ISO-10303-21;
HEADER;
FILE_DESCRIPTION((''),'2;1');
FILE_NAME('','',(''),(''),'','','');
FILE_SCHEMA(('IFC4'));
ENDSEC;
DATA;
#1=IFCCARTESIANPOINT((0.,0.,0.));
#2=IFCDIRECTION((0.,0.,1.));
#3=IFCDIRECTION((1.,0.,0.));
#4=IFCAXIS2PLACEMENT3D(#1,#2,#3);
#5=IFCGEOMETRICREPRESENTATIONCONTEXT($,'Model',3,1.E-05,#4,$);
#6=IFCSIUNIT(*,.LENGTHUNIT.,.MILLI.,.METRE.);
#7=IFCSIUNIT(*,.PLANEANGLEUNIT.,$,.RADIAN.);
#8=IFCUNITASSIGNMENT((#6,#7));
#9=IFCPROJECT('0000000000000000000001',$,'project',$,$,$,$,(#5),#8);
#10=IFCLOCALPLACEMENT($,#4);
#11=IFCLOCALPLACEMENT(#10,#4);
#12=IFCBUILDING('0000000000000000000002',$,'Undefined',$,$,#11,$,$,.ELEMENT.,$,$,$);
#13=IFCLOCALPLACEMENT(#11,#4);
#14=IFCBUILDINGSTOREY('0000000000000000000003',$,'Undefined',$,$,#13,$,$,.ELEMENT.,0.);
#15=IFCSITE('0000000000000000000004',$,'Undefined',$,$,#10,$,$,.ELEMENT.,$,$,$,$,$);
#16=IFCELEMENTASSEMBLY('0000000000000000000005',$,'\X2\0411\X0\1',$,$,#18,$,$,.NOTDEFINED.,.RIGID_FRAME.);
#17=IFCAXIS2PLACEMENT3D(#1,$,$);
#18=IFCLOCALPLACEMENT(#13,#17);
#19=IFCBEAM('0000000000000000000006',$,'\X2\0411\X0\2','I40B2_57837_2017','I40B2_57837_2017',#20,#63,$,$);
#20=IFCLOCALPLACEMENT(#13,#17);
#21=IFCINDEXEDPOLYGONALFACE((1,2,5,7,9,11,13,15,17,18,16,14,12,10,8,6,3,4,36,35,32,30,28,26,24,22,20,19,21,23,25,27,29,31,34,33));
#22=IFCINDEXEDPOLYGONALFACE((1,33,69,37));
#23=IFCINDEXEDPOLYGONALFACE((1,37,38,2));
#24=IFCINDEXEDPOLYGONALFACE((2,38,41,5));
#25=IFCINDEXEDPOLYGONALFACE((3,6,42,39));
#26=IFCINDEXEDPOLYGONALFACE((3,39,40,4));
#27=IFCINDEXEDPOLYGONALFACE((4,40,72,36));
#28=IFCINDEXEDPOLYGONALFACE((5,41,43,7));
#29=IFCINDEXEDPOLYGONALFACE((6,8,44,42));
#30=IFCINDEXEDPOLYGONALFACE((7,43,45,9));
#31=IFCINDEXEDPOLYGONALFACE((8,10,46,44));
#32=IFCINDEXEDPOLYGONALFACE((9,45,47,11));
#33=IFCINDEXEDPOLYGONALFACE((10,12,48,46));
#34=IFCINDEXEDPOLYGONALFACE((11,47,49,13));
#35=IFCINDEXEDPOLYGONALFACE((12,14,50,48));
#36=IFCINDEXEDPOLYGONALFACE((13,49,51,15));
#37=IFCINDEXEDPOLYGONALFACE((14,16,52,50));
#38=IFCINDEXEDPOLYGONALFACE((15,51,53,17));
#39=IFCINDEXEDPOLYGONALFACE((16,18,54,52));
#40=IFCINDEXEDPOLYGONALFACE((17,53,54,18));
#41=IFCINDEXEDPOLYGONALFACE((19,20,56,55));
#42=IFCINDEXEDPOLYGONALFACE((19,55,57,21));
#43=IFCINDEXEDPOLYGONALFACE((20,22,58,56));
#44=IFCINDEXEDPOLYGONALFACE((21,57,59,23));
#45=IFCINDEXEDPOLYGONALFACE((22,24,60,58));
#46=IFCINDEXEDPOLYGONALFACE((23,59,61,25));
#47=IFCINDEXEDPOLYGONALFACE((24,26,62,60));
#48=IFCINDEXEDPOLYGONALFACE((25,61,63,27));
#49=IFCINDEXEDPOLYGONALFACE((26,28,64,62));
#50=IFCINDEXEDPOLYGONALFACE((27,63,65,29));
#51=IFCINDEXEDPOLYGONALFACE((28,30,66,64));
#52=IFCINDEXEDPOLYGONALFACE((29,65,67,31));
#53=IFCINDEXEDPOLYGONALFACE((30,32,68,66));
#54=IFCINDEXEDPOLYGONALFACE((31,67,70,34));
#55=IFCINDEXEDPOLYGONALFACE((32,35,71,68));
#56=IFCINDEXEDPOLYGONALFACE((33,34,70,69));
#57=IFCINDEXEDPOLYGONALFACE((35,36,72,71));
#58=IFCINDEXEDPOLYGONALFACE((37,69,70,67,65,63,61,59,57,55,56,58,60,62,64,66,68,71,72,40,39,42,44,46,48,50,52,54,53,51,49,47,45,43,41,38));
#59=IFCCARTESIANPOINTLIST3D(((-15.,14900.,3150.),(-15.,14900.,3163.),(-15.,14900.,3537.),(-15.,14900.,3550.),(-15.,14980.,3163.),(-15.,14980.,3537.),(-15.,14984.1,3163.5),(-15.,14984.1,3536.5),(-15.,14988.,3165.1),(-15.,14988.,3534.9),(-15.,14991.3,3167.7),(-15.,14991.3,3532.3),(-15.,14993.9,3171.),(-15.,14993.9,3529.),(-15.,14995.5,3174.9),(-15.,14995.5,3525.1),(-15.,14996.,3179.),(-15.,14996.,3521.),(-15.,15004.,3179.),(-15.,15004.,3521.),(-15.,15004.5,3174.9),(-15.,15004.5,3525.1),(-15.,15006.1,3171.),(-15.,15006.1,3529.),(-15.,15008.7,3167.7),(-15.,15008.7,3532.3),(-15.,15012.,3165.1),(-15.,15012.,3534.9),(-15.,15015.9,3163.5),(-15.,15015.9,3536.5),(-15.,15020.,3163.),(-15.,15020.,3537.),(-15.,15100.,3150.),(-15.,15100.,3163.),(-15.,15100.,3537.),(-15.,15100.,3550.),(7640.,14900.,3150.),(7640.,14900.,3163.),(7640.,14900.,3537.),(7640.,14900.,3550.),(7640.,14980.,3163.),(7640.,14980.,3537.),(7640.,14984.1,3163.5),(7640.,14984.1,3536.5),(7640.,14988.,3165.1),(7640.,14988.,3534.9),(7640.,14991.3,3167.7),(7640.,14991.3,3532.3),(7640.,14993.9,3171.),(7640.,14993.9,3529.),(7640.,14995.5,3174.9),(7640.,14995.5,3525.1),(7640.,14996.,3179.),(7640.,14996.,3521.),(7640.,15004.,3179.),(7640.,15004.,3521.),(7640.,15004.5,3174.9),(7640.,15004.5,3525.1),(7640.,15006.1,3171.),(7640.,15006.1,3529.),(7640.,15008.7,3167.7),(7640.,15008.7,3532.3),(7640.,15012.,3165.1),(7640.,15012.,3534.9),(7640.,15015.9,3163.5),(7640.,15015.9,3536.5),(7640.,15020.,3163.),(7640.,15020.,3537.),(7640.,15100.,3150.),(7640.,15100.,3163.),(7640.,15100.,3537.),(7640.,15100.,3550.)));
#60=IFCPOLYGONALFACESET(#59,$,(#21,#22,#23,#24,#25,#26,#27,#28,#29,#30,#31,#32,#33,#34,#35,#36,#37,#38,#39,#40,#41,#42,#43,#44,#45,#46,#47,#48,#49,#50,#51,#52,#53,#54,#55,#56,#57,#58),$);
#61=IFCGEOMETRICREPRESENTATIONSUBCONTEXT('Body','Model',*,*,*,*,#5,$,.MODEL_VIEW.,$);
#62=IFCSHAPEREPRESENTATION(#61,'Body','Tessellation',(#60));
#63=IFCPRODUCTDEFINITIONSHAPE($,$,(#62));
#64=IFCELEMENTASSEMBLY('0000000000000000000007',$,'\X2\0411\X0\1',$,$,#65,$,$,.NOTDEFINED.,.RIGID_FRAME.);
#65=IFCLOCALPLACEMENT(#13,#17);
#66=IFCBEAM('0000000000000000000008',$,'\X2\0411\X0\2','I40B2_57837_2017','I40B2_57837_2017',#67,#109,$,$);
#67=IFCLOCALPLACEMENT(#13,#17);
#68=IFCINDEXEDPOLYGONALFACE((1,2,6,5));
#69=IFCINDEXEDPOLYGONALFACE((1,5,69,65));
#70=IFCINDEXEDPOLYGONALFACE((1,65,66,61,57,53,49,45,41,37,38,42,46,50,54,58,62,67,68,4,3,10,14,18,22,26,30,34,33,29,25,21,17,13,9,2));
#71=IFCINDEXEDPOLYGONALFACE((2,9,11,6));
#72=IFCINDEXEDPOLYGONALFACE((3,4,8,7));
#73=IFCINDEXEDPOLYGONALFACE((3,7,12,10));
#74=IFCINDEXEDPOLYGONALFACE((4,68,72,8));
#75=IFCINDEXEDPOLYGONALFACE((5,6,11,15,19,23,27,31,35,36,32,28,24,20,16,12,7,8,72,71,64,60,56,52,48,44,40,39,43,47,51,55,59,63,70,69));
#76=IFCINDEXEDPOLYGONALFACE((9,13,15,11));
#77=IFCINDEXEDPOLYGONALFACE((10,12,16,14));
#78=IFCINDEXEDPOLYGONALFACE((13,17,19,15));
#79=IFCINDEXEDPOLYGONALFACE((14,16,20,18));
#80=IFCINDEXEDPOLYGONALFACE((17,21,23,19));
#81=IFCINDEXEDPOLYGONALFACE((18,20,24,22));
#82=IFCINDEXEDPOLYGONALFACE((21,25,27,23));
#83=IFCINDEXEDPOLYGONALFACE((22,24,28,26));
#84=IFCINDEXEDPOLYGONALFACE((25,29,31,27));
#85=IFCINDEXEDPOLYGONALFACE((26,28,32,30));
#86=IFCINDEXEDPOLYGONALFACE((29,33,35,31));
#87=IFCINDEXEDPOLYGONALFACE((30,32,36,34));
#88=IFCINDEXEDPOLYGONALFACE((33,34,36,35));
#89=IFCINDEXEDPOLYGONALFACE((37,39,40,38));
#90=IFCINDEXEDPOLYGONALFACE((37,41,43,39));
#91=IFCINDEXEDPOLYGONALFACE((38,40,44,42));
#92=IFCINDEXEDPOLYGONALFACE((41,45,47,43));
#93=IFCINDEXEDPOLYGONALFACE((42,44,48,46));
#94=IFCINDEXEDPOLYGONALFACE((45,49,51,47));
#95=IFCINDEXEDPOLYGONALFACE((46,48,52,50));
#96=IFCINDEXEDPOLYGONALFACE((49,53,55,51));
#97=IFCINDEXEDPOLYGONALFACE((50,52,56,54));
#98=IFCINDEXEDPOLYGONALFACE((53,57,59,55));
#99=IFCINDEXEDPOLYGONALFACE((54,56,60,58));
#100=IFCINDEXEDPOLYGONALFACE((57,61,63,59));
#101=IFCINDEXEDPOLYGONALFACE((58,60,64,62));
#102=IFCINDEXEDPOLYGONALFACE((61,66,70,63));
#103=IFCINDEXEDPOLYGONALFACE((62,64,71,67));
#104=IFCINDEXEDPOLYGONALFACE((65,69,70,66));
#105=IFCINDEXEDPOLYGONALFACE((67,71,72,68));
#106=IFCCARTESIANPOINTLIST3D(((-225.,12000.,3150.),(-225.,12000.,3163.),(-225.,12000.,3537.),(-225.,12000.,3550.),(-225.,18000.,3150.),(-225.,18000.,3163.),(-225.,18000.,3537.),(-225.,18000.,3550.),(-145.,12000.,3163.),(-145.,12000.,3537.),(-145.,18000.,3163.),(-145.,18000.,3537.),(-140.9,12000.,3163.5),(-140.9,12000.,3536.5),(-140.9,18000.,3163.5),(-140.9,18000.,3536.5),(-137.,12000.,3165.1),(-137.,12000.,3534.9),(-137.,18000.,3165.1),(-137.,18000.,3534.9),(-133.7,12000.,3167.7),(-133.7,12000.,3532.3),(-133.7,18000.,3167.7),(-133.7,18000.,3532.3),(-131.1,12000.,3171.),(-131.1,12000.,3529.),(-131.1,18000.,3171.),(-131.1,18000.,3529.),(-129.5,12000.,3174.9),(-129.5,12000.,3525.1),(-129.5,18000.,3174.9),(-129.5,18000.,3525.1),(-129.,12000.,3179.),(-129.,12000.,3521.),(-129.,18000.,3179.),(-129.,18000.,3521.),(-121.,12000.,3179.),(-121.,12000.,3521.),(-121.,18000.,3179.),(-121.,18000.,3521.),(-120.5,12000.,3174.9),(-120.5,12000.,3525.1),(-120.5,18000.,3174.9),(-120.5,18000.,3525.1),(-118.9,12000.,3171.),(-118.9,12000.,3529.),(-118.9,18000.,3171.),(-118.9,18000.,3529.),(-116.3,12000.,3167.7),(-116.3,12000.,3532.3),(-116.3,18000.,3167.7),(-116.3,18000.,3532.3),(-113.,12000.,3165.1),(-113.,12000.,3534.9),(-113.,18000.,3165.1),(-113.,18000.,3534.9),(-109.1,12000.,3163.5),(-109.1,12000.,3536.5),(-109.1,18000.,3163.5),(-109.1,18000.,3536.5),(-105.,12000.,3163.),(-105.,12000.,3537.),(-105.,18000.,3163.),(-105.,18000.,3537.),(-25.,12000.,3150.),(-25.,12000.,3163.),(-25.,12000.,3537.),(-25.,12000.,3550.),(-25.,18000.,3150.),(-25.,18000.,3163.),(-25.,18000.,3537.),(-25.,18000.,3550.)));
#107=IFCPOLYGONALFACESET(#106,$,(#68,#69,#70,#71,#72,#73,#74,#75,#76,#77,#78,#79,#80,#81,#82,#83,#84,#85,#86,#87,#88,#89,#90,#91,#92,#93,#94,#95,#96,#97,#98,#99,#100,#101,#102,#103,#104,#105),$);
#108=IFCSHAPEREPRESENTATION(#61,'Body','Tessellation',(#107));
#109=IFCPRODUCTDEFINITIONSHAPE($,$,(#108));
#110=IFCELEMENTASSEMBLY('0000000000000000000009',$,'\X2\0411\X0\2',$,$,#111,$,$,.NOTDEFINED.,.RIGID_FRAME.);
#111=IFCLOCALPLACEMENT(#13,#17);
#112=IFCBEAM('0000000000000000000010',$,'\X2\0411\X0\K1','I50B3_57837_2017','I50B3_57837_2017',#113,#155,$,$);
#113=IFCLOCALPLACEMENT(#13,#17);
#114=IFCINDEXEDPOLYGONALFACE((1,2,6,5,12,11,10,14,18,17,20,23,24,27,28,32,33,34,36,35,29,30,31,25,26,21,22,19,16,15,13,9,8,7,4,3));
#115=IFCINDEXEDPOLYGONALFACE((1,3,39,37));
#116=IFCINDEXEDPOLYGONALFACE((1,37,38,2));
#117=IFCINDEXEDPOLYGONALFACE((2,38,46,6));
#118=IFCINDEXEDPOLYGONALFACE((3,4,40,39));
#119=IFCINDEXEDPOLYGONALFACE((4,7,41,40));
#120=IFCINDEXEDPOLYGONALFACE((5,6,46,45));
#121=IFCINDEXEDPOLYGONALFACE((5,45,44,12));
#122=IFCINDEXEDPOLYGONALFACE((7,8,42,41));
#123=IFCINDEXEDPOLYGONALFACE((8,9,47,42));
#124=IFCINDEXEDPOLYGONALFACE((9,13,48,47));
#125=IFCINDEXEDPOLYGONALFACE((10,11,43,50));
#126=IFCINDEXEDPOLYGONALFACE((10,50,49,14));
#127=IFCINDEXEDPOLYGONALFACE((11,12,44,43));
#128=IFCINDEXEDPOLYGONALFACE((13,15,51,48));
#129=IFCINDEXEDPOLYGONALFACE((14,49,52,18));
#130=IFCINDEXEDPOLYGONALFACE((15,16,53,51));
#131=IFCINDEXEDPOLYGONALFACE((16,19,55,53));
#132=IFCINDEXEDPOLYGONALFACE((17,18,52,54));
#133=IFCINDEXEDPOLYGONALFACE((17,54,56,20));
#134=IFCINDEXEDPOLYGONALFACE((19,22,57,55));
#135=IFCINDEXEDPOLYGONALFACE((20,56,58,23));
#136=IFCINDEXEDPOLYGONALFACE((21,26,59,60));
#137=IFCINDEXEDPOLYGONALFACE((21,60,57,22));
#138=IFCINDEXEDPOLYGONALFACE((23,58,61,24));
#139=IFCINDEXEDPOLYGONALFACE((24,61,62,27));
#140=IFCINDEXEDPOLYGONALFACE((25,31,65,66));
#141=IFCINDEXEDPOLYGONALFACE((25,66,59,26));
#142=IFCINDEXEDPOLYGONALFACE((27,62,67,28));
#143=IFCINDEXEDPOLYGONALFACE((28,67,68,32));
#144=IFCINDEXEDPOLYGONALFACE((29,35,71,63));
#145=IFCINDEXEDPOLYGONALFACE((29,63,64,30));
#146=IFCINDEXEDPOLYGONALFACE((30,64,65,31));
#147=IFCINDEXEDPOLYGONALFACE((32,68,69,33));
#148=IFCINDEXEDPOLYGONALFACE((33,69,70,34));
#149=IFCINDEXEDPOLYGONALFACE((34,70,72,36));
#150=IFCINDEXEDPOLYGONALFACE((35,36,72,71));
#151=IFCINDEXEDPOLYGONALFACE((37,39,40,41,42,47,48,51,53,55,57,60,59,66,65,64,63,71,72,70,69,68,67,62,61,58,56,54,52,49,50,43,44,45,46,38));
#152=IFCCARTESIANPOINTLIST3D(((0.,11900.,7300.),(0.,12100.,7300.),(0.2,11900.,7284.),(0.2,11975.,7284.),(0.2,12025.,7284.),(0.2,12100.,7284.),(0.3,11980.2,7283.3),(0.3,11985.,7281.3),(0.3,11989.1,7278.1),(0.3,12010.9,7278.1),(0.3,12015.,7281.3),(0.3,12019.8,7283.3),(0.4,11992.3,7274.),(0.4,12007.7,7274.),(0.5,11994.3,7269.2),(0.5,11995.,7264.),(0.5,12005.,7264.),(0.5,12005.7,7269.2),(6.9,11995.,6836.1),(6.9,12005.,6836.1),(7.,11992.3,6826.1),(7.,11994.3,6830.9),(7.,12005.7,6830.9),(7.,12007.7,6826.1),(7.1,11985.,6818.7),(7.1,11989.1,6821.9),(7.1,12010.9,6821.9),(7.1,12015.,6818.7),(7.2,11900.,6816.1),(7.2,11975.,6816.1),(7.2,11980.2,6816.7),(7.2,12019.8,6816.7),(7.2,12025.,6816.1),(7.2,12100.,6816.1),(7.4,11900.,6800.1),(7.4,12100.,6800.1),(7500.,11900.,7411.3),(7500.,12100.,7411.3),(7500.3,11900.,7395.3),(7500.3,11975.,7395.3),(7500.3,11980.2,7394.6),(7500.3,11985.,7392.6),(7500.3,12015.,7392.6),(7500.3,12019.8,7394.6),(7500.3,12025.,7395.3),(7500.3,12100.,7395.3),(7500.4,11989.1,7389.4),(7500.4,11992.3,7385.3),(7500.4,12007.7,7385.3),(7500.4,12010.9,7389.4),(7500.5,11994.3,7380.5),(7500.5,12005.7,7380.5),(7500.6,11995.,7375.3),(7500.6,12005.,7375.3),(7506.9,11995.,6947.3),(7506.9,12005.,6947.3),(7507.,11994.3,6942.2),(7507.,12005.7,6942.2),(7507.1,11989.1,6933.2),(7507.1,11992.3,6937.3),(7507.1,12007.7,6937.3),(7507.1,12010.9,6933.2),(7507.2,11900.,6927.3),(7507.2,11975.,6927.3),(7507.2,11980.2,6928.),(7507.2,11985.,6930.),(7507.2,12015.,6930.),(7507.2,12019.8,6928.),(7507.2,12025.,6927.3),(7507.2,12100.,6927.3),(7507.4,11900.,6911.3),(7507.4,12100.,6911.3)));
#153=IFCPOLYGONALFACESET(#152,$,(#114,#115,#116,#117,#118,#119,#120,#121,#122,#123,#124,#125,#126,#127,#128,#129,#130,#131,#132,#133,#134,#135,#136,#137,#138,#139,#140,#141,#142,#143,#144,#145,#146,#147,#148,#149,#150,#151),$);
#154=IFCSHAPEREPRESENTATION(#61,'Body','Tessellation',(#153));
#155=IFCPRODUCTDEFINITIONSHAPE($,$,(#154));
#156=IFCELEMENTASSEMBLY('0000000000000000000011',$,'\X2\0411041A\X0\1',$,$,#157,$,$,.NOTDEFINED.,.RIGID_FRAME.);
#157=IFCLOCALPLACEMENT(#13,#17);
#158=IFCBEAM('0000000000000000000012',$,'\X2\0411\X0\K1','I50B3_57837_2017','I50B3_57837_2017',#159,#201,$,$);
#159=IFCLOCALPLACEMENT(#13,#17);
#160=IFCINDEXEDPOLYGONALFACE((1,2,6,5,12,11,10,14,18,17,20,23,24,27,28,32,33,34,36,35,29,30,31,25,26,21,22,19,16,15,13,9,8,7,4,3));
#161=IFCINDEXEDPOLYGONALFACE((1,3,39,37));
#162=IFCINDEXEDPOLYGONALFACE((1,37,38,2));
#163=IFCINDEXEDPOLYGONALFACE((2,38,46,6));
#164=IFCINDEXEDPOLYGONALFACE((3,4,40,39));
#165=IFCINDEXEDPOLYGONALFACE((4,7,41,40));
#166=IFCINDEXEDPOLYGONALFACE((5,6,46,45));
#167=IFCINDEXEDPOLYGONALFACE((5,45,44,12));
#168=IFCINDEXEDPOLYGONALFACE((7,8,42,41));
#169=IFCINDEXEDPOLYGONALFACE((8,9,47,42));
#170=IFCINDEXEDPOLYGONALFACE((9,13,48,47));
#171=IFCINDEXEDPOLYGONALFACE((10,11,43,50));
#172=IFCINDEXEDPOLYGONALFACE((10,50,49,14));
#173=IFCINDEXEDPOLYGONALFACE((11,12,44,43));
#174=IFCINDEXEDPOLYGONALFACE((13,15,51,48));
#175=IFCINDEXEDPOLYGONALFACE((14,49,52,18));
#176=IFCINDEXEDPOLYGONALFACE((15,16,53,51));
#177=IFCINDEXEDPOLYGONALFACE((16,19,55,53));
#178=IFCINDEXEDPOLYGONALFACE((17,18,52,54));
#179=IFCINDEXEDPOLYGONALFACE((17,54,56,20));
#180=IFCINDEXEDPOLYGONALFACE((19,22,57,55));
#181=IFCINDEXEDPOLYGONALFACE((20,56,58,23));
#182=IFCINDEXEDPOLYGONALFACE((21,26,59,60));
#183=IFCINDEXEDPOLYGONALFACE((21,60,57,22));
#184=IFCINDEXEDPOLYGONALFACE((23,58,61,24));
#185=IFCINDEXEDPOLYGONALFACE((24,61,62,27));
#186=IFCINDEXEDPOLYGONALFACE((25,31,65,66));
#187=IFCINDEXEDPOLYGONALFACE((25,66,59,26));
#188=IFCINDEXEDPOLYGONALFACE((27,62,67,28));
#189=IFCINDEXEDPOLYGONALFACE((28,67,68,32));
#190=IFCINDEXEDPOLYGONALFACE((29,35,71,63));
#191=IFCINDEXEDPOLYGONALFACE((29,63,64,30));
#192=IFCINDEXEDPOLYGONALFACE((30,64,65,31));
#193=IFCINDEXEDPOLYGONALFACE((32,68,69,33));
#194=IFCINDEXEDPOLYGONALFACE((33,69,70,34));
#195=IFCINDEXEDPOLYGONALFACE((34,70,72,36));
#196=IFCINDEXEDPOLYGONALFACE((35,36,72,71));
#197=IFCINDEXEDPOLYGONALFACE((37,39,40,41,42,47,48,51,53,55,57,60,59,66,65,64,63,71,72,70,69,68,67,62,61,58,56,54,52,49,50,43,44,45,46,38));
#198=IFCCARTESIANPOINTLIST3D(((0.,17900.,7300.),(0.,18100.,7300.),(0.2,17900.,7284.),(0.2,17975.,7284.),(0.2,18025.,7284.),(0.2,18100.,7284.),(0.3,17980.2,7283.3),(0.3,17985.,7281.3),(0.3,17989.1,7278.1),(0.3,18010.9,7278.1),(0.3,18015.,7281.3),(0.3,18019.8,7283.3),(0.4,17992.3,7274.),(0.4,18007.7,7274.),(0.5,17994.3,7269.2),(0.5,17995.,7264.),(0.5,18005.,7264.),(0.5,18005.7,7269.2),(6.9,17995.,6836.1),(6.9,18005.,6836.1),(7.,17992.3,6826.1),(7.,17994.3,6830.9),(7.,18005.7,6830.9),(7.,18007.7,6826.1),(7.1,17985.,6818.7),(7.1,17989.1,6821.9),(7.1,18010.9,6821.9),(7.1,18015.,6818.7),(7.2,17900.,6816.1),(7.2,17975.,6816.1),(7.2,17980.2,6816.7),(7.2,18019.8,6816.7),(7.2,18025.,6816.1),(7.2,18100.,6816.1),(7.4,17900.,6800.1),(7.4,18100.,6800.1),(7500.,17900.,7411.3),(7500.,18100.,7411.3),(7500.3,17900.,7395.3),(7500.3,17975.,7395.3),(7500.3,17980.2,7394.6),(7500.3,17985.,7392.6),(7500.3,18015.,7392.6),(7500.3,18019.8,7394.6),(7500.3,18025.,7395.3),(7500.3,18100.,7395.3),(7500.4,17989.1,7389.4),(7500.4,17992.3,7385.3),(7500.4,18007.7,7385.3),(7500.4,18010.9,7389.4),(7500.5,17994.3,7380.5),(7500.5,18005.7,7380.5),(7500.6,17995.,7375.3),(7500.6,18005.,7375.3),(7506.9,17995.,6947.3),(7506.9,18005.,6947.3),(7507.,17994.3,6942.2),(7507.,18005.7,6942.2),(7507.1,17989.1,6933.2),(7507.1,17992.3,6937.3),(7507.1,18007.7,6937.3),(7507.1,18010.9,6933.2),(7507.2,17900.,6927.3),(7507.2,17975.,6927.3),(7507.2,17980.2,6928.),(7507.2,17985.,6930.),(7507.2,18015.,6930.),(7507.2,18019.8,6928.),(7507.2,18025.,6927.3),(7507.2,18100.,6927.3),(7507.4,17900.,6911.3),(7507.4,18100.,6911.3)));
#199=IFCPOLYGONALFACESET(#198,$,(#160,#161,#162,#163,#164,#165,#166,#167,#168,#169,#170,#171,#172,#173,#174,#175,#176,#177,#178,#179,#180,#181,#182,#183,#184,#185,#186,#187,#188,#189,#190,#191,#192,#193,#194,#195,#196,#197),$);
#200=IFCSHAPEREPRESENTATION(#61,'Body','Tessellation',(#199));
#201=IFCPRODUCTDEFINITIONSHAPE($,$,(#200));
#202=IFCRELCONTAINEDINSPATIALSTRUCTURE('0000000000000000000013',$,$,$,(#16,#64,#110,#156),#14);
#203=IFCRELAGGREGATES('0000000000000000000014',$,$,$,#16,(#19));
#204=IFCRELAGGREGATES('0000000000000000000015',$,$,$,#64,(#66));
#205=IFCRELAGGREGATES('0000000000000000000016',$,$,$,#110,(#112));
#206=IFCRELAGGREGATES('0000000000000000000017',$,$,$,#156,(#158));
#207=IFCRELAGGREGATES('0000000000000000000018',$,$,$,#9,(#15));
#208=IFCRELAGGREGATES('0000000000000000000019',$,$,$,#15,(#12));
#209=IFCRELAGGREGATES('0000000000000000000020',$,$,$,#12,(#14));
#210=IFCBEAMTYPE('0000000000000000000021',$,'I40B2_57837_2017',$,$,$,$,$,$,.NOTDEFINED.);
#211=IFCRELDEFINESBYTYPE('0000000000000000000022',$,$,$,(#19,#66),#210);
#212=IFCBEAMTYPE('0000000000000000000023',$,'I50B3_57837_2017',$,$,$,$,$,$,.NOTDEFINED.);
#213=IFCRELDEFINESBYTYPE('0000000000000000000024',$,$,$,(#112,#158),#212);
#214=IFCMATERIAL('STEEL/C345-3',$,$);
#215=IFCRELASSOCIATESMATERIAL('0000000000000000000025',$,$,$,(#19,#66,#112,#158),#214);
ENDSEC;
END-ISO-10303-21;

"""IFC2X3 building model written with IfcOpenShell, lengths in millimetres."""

from ifc_helpers import new_model, si_unit, frame, origin_with_axes, origin_2d_with_axis, place, context, subcontext, project, spatial, i_section, extrude, material, type_object, element, aggregate, save


model = new_model("IFC2X3")

# Units and contexts
model_context = context("Model", 3, precision=1e-05, world=origin_with_axes())
body_context = subcontext(model_context, "Body", "Model", "MODEL_VIEW")
ifc_project = project(units=[si_unit("LENGTHUNIT", "METRE", prefix="MILLI"), si_unit("PLANEANGLEUNIT", "RADIAN")], contexts=[model_context])

# Site, building, storey
site_placement = place(None, origin_with_axes())
site = spatial("IfcSite", under=ifc_project, at=site_placement, Name="Undefined", CompositionType="ELEMENT")
building_placement = place(site_placement, origin_with_axes())
building = spatial("IfcBuilding", under=site, at=building_placement, Name="Undefined", CompositionType="ELEMENT")
storey_placement = place(building_placement, origin_with_axes())
storey = spatial("IfcBuildingStorey", under=building, at=storey_placement, Name="Undefined", CompositionType="ELEMENT", Elevation=0.0)

# Element assemblies, beams
assembly_1_placement = place(storey_placement, origin_with_axes())
assembly_1 = element("IfcElementAssembly", 1, at=assembly_1_placement, inside=storey, Name="Б1", AssemblyPlace="NOTDEFINED", PredefinedType="RIGID_FRAME")
ifc_material_1 = material(Name="STEEL/C345-3")
beam_type_1 = type_object("IfcBeamType", Name="I40B2_57837_2017", PredefinedType="NOTDEFINED")
beam_1_placement = place(assembly_1_placement, frame((-15.0, 15000.0, 3350.0), z_axis=(0.0, 0.0, -1.0), x_axis=(1.0, 0.0, 0.0)))
beam_1 = element("IfcBeam", 2, at=beam_1_placement, type_object=beam_type_1, material=ifc_material_1, Name="Б2", Description="I40B2_57837_2017", ObjectType="I40B2_57837_2017", context=body_context, shape_type="SweptSolid", body=[
    extrude(i_section(OverallWidth=200.0, OverallDepth=400.0, WebThickness=8.0, FlangeThickness=13.0, FilletRadius=16.0, at=origin_2d_with_axis()), frame((7655.0, 0.0, 0.0), z_axis=(-1.0, 0.0, 0.0), x_axis=(0.0, -1.0, 0.0)), (0.0, 0.0, 1.0), 7655.0),
])
aggregate(assembly_1, [beam_1])
assembly_2_placement = place(storey_placement, origin_with_axes())
assembly_2 = element("IfcElementAssembly", 3, at=assembly_2_placement, inside=storey, Name="Б1", AssemblyPlace="NOTDEFINED", PredefinedType="RIGID_FRAME")
beam_2_placement = place(assembly_2_placement, frame((-125.0, 18000.0, 3350.0), z_axis=(0.0, 0.0, -1.0), x_axis=(0.0, -1.0, 0.0)))
beam_2 = element("IfcBeam", 4, at=beam_2_placement, type_object=beam_type_1, material=ifc_material_1, Name="Б2", Description="I40B2_57837_2017", ObjectType="I40B2_57837_2017", context=body_context, shape_type="SweptSolid", body=[
    extrude(i_section(OverallWidth=200.0, OverallDepth=400.0, WebThickness=8.0, FlangeThickness=13.0, FilletRadius=16.0, at=origin_2d_with_axis()), frame((6000.0, 0.0, 0.0), z_axis=(-1.0, 0.0, 0.0), x_axis=(0.0, -1.0, 0.0)), (0.0, 0.0, 1.0), 6000.0),
])
aggregate(assembly_2, [beam_2])
assembly_3_placement = place(storey_placement, origin_with_axes())
assembly_3 = element("IfcElementAssembly", 5, at=assembly_3_placement, inside=storey, Name="Б2", AssemblyPlace="NOTDEFINED", PredefinedType="RIGID_FRAME")
beam_type_2 = type_object("IfcBeamType", Name="I50B3_57837_2017", PredefinedType="NOTDEFINED")
beam_3_placement = place(assembly_3_placement, frame((3.7, 12000.0, 7050.0), z_axis=(0.014837, 0.0, -0.99989), x_axis=(0.99989, 0.0, 0.014837)))
beam_3 = element("IfcBeam", 6, at=beam_3_placement, type_object=beam_type_2, material=ifc_material_1, Name="БK1", Description="I50B3_57837_2017", ObjectType="I50B3_57837_2017", context=body_context, shape_type="SweptSolid", body=[
    extrude(i_section(OverallWidth=200.0, OverallDepth=500.0, WebThickness=10.0, FlangeThickness=16.0, FilletRadius=20.0, at=origin_2d_with_axis()), frame((7500.9, 0.0, 0.0), z_axis=(-1.0, 0.0, 0.0), x_axis=(0.0, -1.0, 0.0)), (0.0, 0.0, 1.0), 7500.9),
])
aggregate(assembly_3, [beam_3])
assembly_4_placement = place(storey_placement, origin_with_axes())
assembly_4 = element("IfcElementAssembly", 7, at=assembly_4_placement, inside=storey, Name="БК1", AssemblyPlace="NOTDEFINED", PredefinedType="RIGID_FRAME")
beam_4_placement = place(assembly_4_placement, frame((3.7, 18000.0, 7050.0), z_axis=(0.014837, 0.0, -0.99989), x_axis=(0.99989, 0.0, 0.014837)))
beam_4 = element("IfcBeam", 8, at=beam_4_placement, type_object=beam_type_2, material=ifc_material_1, Name="БK1", Description="I50B3_57837_2017", ObjectType="I50B3_57837_2017", context=body_context, shape_type="SweptSolid", body=[
    extrude(i_section(OverallWidth=200.0, OverallDepth=500.0, WebThickness=10.0, FlangeThickness=16.0, FilletRadius=20.0, at=origin_2d_with_axis()), frame((7500.9, 0.0, 0.0), z_axis=(-1.0, 0.0, 0.0), x_axis=(0.0, -1.0, 0.0)), (0.0, 0.0, 1.0), 7500.9),
])
aggregate(assembly_4, [beam_4])

save(model, "model.ifc")
